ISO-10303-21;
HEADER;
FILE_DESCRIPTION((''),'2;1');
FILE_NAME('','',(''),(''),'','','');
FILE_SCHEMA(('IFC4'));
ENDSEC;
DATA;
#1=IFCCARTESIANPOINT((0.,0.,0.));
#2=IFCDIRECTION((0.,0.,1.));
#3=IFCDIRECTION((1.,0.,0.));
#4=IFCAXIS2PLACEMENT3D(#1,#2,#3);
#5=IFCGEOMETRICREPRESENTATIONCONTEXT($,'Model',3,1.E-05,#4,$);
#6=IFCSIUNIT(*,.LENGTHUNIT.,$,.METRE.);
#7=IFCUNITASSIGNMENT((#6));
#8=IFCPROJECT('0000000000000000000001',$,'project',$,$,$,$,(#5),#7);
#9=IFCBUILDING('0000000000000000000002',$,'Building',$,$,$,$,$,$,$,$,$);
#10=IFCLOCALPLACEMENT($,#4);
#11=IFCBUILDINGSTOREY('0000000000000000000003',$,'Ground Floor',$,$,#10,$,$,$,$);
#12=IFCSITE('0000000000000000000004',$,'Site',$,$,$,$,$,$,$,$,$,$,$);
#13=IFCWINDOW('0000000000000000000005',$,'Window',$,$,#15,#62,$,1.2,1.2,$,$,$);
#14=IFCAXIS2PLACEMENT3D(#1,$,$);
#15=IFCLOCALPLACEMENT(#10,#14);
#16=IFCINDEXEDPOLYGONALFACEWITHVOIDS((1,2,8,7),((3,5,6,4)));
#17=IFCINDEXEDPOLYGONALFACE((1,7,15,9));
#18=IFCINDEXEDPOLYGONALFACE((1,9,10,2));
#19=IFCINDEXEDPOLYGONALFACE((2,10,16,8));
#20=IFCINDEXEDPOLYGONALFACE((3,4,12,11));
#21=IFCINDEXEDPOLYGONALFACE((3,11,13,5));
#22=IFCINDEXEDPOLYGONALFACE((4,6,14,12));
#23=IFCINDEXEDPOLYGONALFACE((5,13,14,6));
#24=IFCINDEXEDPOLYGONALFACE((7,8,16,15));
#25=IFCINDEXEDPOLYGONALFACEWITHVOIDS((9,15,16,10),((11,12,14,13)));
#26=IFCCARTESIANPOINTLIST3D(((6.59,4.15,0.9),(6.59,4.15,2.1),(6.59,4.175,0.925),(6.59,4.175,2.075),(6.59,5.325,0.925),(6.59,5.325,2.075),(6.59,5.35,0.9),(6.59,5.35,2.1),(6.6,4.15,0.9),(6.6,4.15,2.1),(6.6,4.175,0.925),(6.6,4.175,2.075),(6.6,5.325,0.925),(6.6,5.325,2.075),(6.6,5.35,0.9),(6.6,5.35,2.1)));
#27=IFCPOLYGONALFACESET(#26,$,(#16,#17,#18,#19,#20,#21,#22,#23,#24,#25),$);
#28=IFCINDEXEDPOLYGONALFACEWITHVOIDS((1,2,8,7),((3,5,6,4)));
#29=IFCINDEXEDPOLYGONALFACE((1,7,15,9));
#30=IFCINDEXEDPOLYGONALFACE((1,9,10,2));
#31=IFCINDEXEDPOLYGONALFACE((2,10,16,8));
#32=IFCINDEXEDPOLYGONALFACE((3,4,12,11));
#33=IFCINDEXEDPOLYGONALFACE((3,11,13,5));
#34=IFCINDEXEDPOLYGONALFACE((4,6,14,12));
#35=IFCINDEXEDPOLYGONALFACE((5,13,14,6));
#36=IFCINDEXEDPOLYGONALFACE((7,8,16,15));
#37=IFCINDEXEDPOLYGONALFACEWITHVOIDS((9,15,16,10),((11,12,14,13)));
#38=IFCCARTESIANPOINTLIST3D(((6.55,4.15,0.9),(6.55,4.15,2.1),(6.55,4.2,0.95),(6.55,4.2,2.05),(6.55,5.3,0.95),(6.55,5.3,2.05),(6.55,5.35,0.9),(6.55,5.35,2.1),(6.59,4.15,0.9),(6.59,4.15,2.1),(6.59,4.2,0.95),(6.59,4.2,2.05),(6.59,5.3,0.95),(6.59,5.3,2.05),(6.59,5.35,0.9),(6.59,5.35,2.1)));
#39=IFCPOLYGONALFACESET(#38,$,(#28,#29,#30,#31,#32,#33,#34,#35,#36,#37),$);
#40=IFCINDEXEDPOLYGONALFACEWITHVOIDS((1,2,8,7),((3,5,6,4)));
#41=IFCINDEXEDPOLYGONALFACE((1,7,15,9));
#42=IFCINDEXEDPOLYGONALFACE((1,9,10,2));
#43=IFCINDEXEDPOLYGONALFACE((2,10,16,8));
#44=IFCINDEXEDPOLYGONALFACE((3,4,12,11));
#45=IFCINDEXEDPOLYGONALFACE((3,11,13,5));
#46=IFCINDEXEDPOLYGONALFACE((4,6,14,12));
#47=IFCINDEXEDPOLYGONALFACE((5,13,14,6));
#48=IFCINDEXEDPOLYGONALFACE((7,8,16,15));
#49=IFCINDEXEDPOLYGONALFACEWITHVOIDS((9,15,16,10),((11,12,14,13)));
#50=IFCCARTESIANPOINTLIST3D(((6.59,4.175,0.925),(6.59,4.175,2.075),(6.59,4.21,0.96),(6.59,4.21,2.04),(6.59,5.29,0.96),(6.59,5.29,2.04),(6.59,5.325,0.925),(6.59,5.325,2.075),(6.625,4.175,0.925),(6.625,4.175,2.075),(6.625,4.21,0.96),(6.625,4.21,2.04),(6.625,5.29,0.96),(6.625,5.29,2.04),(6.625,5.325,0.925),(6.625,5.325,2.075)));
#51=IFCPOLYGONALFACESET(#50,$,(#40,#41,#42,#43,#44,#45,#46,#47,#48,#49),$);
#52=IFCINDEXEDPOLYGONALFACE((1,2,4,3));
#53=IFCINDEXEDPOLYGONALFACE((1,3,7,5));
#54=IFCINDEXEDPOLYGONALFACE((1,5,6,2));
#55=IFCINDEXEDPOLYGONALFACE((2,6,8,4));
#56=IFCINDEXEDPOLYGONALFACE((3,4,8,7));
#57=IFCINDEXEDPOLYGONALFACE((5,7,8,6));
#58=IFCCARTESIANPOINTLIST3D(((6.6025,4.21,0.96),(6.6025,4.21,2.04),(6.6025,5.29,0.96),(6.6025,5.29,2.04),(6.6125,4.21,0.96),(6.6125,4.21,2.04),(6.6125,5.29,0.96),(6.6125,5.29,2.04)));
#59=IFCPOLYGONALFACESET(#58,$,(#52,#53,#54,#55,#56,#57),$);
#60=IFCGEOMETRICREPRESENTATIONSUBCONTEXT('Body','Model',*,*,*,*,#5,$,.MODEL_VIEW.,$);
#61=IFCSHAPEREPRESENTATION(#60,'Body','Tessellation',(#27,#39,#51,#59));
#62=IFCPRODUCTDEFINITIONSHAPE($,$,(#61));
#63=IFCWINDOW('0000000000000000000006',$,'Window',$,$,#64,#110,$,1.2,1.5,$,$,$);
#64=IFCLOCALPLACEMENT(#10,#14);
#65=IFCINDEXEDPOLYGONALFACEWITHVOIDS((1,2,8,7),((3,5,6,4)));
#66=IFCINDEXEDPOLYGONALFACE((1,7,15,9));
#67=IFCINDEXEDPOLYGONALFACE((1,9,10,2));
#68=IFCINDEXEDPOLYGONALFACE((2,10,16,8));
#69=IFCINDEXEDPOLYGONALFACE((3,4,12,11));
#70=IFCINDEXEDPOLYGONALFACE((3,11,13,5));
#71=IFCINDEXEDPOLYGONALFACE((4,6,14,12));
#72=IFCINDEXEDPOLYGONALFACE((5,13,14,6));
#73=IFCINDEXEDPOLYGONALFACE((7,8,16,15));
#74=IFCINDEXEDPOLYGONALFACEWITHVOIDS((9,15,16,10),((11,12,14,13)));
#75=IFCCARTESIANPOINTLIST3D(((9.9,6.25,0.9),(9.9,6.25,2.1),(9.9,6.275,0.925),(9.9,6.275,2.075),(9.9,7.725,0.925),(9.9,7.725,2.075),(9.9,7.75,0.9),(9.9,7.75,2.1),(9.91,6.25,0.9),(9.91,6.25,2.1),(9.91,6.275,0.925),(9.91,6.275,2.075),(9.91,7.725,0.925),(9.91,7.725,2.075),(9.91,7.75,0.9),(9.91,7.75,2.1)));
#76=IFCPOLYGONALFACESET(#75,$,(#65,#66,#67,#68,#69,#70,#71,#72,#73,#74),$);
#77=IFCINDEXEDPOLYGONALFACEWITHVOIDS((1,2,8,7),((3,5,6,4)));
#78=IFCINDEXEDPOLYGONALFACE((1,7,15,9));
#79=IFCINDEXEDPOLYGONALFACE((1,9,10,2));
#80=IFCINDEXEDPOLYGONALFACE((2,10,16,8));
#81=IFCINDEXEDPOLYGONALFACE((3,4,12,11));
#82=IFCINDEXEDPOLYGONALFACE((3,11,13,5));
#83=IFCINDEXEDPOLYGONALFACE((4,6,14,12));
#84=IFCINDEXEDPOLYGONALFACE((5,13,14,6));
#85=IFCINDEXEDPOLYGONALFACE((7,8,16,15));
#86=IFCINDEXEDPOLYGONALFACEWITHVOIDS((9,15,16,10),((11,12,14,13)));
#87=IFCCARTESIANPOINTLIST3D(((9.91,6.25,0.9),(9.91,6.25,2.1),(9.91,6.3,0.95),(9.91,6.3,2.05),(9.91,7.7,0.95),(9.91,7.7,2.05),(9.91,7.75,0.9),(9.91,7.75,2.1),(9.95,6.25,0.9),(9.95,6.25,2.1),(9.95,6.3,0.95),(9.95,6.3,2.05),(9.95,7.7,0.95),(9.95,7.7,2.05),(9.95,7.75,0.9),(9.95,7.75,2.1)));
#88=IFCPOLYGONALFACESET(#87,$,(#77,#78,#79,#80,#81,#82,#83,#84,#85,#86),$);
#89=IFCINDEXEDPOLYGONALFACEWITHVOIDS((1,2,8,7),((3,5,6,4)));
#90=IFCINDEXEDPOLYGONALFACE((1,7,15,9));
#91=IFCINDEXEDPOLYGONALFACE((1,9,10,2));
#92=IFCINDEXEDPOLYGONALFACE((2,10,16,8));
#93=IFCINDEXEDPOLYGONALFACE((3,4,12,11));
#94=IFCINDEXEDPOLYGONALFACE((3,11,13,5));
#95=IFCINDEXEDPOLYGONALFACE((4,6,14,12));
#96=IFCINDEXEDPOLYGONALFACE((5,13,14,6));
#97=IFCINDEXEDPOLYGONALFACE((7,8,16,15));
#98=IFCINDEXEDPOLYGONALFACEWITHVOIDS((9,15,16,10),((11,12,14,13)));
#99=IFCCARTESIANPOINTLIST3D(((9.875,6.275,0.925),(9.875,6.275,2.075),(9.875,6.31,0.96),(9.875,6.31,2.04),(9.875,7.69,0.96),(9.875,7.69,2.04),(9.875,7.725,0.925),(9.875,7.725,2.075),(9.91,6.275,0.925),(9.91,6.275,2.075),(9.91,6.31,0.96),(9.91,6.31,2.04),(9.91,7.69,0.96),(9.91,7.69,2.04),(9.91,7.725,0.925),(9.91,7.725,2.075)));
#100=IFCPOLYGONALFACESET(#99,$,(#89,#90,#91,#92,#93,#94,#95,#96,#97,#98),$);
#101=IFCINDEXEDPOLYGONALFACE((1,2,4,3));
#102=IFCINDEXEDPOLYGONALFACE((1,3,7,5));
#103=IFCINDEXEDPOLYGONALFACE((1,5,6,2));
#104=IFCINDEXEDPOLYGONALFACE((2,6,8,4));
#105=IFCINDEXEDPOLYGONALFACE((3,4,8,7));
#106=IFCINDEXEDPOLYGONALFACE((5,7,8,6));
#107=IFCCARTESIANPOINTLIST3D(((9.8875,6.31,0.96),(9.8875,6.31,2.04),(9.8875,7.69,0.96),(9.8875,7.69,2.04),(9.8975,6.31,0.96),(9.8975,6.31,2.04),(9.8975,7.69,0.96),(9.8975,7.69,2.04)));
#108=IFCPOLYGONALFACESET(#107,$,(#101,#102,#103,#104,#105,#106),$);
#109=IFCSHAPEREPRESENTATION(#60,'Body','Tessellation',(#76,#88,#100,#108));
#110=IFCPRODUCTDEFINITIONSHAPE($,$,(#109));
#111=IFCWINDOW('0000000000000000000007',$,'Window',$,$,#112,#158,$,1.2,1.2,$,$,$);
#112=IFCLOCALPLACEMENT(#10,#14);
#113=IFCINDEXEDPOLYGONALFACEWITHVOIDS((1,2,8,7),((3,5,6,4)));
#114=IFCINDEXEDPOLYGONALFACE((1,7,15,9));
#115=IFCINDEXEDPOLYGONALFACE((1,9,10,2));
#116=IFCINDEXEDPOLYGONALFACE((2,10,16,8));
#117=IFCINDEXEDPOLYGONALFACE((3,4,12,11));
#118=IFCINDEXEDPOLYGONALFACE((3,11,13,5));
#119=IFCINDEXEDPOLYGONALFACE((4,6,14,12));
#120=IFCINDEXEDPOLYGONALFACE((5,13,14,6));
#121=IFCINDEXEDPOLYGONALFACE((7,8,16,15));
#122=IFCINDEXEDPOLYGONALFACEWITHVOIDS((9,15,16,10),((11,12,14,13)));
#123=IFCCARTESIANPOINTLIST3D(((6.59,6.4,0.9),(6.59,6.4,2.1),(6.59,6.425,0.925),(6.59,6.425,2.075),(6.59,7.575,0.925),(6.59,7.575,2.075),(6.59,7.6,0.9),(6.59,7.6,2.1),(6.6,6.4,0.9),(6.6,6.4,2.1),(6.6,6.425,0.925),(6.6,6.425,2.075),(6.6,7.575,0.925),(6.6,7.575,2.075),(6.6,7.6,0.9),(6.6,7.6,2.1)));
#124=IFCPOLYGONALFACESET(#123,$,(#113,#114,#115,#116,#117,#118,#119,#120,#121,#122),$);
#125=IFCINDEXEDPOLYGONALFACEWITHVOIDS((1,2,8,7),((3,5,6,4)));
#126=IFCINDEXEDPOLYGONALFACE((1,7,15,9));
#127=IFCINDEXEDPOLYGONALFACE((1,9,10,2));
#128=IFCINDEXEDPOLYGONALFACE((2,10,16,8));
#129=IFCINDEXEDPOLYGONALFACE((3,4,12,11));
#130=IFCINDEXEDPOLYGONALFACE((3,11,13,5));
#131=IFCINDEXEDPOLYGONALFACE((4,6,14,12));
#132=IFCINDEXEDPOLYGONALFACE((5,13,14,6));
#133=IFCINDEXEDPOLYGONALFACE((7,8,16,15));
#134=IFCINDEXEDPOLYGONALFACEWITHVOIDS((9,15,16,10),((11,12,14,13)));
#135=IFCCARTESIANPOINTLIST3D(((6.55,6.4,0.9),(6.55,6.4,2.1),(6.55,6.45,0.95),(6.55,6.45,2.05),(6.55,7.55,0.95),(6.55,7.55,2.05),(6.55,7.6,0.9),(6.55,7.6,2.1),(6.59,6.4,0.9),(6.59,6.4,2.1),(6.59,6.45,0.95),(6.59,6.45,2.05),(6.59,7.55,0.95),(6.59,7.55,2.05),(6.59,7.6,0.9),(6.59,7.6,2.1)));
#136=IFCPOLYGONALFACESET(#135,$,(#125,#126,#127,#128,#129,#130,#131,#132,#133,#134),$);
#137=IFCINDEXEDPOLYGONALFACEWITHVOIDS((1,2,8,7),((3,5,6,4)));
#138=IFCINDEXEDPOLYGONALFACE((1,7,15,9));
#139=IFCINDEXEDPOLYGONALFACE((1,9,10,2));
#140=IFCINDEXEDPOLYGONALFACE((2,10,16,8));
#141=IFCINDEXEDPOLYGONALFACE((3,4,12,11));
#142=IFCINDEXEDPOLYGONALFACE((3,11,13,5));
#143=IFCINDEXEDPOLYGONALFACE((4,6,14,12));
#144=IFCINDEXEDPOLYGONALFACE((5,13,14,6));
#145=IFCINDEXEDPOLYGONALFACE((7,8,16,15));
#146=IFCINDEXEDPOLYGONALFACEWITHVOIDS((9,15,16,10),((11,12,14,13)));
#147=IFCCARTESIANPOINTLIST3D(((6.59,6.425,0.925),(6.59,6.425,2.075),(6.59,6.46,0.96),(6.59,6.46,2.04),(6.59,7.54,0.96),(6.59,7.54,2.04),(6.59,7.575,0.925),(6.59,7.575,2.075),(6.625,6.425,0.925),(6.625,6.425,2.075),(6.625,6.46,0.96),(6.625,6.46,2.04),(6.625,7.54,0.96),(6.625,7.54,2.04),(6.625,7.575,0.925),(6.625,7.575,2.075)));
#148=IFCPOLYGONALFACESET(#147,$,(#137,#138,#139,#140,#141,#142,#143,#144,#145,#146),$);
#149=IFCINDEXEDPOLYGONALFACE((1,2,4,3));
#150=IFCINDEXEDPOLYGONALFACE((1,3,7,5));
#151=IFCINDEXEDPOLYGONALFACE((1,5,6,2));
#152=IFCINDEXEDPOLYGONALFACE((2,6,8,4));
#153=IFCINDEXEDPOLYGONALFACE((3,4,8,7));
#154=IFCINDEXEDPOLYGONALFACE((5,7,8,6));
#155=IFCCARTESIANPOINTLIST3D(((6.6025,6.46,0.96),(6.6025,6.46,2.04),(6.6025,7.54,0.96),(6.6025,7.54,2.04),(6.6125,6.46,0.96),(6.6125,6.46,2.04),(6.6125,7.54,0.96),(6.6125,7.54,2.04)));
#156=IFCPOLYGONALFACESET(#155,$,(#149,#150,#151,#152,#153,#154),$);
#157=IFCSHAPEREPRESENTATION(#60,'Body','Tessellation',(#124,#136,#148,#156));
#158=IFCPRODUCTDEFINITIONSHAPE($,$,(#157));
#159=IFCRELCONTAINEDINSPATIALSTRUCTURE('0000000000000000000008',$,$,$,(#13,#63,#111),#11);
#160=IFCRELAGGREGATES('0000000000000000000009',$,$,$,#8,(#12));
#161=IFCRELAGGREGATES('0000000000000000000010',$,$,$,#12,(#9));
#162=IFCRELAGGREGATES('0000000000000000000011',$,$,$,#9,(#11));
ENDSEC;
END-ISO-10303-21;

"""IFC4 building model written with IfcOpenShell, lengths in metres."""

from ifc_helpers import new_model, si_unit, frame, origin_with_axes, place, context, subcontext, project, spatial, line, indexed_curve, outline, extrude, element, save


model = new_model("IFC4")

# Units and contexts
model_context = context("Model", 3, precision=1e-05, world=origin_with_axes())
body_context = subcontext(model_context, "Body", "Model", "MODEL_VIEW")
ifc_project = project(units=[si_unit("LENGTHUNIT", "METRE")], contexts=[model_context])

# Site, building, storey
site = spatial("IfcSite", under=ifc_project, Name="Site")
building = spatial("IfcBuilding", under=site, Name="Building")
storey_placement = place(None, origin_with_axes())
storey = spatial("IfcBuildingStorey", under=building, at=storey_placement, Name="Ground Floor")

# Windows
window_1_placement = place(storey_placement, frame((6.5, 5.35, 0.9), z_axis=(0.0, 0.0, 1.0), x_axis=(0.0, -1.0, 0.0)))
element("IfcWindow", 1, at=window_1_placement, inside=storey, Name="Window", OverallHeight=1.2, OverallWidth=1.2, context=body_context, shape_type="SweptSolid", body=[
    extrude(outline(indexed_curve([(0.0, 0.0), (1.2, 0.0), (1.2, 1.2), (0.0, 1.2)], segments=[line(1, 2, 3, 4, 1)]), holes=[indexed_curve([(0.025, 0.025), (1.175, 0.025), (1.175, 1.175), (0.025, 1.175)], segments=[line(1, 2, 3, 4, 1)])]), frame((0.0, 0.09, 0.0), z_axis=(0.0, -1.0, 0.0), x_axis=(1.0, 0.0, 0.0)), (0.0, 0.0, -1.0), 0.01),
    extrude(outline(indexed_curve([(0.0, 0.0), (1.2, 0.0), (1.2, 1.2), (0.0, 1.2)], segments=[line(1, 2, 3, 4, 1)]), holes=[indexed_curve([(0.05, 0.05), (1.15, 0.05), (1.15, 1.15), (0.05, 1.15)], segments=[line(1, 2, 3, 4, 1)])]), frame((0.0, 0.05, 0.0), z_axis=(0.0, -1.0, 0.0), x_axis=(1.0, 0.0, 0.0)), (0.0, 0.0, -1.0), 0.04),
    extrude(outline(indexed_curve([(0.0, 0.0), (1.15, 0.0), (1.15, 1.15), (0.0, 1.15)], segments=[line(1, 2, 3, 4, 1)]), holes=[indexed_curve([(0.035, 0.035), (1.115, 0.035), (1.115, 1.115), (0.035, 1.115)], segments=[line(1, 2, 3, 4, 1)])]), frame((0.025, 0.09, 0.025), z_axis=(0.0, -1.0, 0.0), x_axis=(1.0, 0.0, 0.0)), (0.0, 0.0, -1.0), 0.035),
    extrude(outline(indexed_curve([(0.035, 0.035), (1.115, 0.035), (1.115, 1.115), (0.035, 1.115)], segments=[line(1, 2, 3, 4, 1)])), frame((0.025, 0.1025, 0.025), z_axis=(0.0, -1.0, 0.0), x_axis=(1.0, 0.0, 0.0)), (0.0, 0.0, -1.0), 0.01),
])
window_2_placement = place(storey_placement, frame((10.0, 6.25, 0.9), z_axis=(0.0, 0.0, 1.0), x_axis=(0.0, 1.0, 0.0)))
element("IfcWindow", 2, at=window_2_placement, inside=storey, Name="Window", OverallHeight=1.2, OverallWidth=1.5, context=body_context, shape_type="SweptSolid", body=[
    extrude(outline(indexed_curve([(0.0, 0.0), (1.5, 0.0), (1.5, 1.2), (0.0, 1.2)], segments=[line(1, 2, 3, 4, 1)]), holes=[indexed_curve([(0.025, 0.025), (1.475, 0.025), (1.475, 1.175), (0.025, 1.175)], segments=[line(1, 2, 3, 4, 1)])]), frame((0.0, 0.09, 0.0), z_axis=(0.0, -1.0, 0.0), x_axis=(1.0, 0.0, 0.0)), (0.0, 0.0, -1.0), 0.01),
    extrude(outline(indexed_curve([(0.0, 0.0), (1.5, 0.0), (1.5, 1.2), (0.0, 1.2)], segments=[line(1, 2, 3, 4, 1)]), holes=[indexed_curve([(0.05, 0.05), (1.45, 0.05), (1.45, 1.15), (0.05, 1.15)], segments=[line(1, 2, 3, 4, 1)])]), frame((0.0, 0.05, 0.0), z_axis=(0.0, -1.0, 0.0), x_axis=(1.0, 0.0, 0.0)), (0.0, 0.0, -1.0), 0.04),
    extrude(outline(indexed_curve([(0.0, 0.0), (1.45, 0.0), (1.45, 1.15), (0.0, 1.15)], segments=[line(1, 2, 3, 4, 1)]), holes=[indexed_curve([(0.035, 0.035), (1.415, 0.035), (1.415, 1.115), (0.035, 1.115)], segments=[line(1, 2, 3, 4, 1)])]), frame((0.025, 0.09, 0.025), z_axis=(0.0, -1.0, 0.0), x_axis=(1.0, 0.0, 0.0)), (0.0, 0.0, -1.0), 0.035),
    extrude(outline(indexed_curve([(0.035, 0.035), (1.415, 0.035), (1.415, 1.115), (0.035, 1.115)], segments=[line(1, 2, 3, 4, 1)])), frame((0.025, 0.1025, 0.025), z_axis=(0.0, -1.0, 0.0), x_axis=(1.0, 0.0, 0.0)), (0.0, 0.0, -1.0), 0.01),
])
window_3_placement = place(storey_placement, frame((6.5, 7.6, 0.9), z_axis=(0.0, 0.0, 1.0), x_axis=(0.0, -1.0, 0.0)))
element("IfcWindow", 3, at=window_3_placement, inside=storey, Name="Window", OverallHeight=1.2, OverallWidth=1.2, context=body_context, shape_type="SweptSolid", body=[
    extrude(outline(indexed_curve([(0.0, 0.0), (1.2, 0.0), (1.2, 1.2), (0.0, 1.2)], segments=[line(1, 2, 3, 4, 1)]), holes=[indexed_curve([(0.025, 0.025), (1.175, 0.025), (1.175, 1.175), (0.025, 1.175)], segments=[line(1, 2, 3, 4, 1)])]), frame((0.0, 0.09, 0.0), z_axis=(0.0, -1.0, 0.0), x_axis=(1.0, 0.0, 0.0)), (0.0, 0.0, -1.0), 0.01),
    extrude(outline(indexed_curve([(0.0, 0.0), (1.2, 0.0), (1.2, 1.2), (0.0, 1.2)], segments=[line(1, 2, 3, 4, 1)]), holes=[indexed_curve([(0.05, 0.05), (1.15, 0.05), (1.15, 1.15), (0.05, 1.15)], segments=[line(1, 2, 3, 4, 1)])]), frame((0.0, 0.05, 0.0), z_axis=(0.0, -1.0, 0.0), x_axis=(1.0, 0.0, 0.0)), (0.0, 0.0, -1.0), 0.04),
    extrude(outline(indexed_curve([(0.0, 0.0), (1.15, 0.0), (1.15, 1.15), (0.0, 1.15)], segments=[line(1, 2, 3, 4, 1)]), holes=[indexed_curve([(0.035, 0.035), (1.115, 0.035), (1.115, 1.115), (0.035, 1.115)], segments=[line(1, 2, 3, 4, 1)])]), frame((0.025, 0.09, 0.025), z_axis=(0.0, -1.0, 0.0), x_axis=(1.0, 0.0, 0.0)), (0.0, 0.0, -1.0), 0.035),
    extrude(outline(indexed_curve([(0.035, 0.035), (1.115, 0.035), (1.115, 1.115), (0.035, 1.115)], segments=[line(1, 2, 3, 4, 1)])), frame((0.025, 0.1025, 0.025), z_axis=(0.0, -1.0, 0.0), x_axis=(1.0, 0.0, 0.0)), (0.0, 0.0, -1.0), 0.01),
])

save(model, "model.ifc")
